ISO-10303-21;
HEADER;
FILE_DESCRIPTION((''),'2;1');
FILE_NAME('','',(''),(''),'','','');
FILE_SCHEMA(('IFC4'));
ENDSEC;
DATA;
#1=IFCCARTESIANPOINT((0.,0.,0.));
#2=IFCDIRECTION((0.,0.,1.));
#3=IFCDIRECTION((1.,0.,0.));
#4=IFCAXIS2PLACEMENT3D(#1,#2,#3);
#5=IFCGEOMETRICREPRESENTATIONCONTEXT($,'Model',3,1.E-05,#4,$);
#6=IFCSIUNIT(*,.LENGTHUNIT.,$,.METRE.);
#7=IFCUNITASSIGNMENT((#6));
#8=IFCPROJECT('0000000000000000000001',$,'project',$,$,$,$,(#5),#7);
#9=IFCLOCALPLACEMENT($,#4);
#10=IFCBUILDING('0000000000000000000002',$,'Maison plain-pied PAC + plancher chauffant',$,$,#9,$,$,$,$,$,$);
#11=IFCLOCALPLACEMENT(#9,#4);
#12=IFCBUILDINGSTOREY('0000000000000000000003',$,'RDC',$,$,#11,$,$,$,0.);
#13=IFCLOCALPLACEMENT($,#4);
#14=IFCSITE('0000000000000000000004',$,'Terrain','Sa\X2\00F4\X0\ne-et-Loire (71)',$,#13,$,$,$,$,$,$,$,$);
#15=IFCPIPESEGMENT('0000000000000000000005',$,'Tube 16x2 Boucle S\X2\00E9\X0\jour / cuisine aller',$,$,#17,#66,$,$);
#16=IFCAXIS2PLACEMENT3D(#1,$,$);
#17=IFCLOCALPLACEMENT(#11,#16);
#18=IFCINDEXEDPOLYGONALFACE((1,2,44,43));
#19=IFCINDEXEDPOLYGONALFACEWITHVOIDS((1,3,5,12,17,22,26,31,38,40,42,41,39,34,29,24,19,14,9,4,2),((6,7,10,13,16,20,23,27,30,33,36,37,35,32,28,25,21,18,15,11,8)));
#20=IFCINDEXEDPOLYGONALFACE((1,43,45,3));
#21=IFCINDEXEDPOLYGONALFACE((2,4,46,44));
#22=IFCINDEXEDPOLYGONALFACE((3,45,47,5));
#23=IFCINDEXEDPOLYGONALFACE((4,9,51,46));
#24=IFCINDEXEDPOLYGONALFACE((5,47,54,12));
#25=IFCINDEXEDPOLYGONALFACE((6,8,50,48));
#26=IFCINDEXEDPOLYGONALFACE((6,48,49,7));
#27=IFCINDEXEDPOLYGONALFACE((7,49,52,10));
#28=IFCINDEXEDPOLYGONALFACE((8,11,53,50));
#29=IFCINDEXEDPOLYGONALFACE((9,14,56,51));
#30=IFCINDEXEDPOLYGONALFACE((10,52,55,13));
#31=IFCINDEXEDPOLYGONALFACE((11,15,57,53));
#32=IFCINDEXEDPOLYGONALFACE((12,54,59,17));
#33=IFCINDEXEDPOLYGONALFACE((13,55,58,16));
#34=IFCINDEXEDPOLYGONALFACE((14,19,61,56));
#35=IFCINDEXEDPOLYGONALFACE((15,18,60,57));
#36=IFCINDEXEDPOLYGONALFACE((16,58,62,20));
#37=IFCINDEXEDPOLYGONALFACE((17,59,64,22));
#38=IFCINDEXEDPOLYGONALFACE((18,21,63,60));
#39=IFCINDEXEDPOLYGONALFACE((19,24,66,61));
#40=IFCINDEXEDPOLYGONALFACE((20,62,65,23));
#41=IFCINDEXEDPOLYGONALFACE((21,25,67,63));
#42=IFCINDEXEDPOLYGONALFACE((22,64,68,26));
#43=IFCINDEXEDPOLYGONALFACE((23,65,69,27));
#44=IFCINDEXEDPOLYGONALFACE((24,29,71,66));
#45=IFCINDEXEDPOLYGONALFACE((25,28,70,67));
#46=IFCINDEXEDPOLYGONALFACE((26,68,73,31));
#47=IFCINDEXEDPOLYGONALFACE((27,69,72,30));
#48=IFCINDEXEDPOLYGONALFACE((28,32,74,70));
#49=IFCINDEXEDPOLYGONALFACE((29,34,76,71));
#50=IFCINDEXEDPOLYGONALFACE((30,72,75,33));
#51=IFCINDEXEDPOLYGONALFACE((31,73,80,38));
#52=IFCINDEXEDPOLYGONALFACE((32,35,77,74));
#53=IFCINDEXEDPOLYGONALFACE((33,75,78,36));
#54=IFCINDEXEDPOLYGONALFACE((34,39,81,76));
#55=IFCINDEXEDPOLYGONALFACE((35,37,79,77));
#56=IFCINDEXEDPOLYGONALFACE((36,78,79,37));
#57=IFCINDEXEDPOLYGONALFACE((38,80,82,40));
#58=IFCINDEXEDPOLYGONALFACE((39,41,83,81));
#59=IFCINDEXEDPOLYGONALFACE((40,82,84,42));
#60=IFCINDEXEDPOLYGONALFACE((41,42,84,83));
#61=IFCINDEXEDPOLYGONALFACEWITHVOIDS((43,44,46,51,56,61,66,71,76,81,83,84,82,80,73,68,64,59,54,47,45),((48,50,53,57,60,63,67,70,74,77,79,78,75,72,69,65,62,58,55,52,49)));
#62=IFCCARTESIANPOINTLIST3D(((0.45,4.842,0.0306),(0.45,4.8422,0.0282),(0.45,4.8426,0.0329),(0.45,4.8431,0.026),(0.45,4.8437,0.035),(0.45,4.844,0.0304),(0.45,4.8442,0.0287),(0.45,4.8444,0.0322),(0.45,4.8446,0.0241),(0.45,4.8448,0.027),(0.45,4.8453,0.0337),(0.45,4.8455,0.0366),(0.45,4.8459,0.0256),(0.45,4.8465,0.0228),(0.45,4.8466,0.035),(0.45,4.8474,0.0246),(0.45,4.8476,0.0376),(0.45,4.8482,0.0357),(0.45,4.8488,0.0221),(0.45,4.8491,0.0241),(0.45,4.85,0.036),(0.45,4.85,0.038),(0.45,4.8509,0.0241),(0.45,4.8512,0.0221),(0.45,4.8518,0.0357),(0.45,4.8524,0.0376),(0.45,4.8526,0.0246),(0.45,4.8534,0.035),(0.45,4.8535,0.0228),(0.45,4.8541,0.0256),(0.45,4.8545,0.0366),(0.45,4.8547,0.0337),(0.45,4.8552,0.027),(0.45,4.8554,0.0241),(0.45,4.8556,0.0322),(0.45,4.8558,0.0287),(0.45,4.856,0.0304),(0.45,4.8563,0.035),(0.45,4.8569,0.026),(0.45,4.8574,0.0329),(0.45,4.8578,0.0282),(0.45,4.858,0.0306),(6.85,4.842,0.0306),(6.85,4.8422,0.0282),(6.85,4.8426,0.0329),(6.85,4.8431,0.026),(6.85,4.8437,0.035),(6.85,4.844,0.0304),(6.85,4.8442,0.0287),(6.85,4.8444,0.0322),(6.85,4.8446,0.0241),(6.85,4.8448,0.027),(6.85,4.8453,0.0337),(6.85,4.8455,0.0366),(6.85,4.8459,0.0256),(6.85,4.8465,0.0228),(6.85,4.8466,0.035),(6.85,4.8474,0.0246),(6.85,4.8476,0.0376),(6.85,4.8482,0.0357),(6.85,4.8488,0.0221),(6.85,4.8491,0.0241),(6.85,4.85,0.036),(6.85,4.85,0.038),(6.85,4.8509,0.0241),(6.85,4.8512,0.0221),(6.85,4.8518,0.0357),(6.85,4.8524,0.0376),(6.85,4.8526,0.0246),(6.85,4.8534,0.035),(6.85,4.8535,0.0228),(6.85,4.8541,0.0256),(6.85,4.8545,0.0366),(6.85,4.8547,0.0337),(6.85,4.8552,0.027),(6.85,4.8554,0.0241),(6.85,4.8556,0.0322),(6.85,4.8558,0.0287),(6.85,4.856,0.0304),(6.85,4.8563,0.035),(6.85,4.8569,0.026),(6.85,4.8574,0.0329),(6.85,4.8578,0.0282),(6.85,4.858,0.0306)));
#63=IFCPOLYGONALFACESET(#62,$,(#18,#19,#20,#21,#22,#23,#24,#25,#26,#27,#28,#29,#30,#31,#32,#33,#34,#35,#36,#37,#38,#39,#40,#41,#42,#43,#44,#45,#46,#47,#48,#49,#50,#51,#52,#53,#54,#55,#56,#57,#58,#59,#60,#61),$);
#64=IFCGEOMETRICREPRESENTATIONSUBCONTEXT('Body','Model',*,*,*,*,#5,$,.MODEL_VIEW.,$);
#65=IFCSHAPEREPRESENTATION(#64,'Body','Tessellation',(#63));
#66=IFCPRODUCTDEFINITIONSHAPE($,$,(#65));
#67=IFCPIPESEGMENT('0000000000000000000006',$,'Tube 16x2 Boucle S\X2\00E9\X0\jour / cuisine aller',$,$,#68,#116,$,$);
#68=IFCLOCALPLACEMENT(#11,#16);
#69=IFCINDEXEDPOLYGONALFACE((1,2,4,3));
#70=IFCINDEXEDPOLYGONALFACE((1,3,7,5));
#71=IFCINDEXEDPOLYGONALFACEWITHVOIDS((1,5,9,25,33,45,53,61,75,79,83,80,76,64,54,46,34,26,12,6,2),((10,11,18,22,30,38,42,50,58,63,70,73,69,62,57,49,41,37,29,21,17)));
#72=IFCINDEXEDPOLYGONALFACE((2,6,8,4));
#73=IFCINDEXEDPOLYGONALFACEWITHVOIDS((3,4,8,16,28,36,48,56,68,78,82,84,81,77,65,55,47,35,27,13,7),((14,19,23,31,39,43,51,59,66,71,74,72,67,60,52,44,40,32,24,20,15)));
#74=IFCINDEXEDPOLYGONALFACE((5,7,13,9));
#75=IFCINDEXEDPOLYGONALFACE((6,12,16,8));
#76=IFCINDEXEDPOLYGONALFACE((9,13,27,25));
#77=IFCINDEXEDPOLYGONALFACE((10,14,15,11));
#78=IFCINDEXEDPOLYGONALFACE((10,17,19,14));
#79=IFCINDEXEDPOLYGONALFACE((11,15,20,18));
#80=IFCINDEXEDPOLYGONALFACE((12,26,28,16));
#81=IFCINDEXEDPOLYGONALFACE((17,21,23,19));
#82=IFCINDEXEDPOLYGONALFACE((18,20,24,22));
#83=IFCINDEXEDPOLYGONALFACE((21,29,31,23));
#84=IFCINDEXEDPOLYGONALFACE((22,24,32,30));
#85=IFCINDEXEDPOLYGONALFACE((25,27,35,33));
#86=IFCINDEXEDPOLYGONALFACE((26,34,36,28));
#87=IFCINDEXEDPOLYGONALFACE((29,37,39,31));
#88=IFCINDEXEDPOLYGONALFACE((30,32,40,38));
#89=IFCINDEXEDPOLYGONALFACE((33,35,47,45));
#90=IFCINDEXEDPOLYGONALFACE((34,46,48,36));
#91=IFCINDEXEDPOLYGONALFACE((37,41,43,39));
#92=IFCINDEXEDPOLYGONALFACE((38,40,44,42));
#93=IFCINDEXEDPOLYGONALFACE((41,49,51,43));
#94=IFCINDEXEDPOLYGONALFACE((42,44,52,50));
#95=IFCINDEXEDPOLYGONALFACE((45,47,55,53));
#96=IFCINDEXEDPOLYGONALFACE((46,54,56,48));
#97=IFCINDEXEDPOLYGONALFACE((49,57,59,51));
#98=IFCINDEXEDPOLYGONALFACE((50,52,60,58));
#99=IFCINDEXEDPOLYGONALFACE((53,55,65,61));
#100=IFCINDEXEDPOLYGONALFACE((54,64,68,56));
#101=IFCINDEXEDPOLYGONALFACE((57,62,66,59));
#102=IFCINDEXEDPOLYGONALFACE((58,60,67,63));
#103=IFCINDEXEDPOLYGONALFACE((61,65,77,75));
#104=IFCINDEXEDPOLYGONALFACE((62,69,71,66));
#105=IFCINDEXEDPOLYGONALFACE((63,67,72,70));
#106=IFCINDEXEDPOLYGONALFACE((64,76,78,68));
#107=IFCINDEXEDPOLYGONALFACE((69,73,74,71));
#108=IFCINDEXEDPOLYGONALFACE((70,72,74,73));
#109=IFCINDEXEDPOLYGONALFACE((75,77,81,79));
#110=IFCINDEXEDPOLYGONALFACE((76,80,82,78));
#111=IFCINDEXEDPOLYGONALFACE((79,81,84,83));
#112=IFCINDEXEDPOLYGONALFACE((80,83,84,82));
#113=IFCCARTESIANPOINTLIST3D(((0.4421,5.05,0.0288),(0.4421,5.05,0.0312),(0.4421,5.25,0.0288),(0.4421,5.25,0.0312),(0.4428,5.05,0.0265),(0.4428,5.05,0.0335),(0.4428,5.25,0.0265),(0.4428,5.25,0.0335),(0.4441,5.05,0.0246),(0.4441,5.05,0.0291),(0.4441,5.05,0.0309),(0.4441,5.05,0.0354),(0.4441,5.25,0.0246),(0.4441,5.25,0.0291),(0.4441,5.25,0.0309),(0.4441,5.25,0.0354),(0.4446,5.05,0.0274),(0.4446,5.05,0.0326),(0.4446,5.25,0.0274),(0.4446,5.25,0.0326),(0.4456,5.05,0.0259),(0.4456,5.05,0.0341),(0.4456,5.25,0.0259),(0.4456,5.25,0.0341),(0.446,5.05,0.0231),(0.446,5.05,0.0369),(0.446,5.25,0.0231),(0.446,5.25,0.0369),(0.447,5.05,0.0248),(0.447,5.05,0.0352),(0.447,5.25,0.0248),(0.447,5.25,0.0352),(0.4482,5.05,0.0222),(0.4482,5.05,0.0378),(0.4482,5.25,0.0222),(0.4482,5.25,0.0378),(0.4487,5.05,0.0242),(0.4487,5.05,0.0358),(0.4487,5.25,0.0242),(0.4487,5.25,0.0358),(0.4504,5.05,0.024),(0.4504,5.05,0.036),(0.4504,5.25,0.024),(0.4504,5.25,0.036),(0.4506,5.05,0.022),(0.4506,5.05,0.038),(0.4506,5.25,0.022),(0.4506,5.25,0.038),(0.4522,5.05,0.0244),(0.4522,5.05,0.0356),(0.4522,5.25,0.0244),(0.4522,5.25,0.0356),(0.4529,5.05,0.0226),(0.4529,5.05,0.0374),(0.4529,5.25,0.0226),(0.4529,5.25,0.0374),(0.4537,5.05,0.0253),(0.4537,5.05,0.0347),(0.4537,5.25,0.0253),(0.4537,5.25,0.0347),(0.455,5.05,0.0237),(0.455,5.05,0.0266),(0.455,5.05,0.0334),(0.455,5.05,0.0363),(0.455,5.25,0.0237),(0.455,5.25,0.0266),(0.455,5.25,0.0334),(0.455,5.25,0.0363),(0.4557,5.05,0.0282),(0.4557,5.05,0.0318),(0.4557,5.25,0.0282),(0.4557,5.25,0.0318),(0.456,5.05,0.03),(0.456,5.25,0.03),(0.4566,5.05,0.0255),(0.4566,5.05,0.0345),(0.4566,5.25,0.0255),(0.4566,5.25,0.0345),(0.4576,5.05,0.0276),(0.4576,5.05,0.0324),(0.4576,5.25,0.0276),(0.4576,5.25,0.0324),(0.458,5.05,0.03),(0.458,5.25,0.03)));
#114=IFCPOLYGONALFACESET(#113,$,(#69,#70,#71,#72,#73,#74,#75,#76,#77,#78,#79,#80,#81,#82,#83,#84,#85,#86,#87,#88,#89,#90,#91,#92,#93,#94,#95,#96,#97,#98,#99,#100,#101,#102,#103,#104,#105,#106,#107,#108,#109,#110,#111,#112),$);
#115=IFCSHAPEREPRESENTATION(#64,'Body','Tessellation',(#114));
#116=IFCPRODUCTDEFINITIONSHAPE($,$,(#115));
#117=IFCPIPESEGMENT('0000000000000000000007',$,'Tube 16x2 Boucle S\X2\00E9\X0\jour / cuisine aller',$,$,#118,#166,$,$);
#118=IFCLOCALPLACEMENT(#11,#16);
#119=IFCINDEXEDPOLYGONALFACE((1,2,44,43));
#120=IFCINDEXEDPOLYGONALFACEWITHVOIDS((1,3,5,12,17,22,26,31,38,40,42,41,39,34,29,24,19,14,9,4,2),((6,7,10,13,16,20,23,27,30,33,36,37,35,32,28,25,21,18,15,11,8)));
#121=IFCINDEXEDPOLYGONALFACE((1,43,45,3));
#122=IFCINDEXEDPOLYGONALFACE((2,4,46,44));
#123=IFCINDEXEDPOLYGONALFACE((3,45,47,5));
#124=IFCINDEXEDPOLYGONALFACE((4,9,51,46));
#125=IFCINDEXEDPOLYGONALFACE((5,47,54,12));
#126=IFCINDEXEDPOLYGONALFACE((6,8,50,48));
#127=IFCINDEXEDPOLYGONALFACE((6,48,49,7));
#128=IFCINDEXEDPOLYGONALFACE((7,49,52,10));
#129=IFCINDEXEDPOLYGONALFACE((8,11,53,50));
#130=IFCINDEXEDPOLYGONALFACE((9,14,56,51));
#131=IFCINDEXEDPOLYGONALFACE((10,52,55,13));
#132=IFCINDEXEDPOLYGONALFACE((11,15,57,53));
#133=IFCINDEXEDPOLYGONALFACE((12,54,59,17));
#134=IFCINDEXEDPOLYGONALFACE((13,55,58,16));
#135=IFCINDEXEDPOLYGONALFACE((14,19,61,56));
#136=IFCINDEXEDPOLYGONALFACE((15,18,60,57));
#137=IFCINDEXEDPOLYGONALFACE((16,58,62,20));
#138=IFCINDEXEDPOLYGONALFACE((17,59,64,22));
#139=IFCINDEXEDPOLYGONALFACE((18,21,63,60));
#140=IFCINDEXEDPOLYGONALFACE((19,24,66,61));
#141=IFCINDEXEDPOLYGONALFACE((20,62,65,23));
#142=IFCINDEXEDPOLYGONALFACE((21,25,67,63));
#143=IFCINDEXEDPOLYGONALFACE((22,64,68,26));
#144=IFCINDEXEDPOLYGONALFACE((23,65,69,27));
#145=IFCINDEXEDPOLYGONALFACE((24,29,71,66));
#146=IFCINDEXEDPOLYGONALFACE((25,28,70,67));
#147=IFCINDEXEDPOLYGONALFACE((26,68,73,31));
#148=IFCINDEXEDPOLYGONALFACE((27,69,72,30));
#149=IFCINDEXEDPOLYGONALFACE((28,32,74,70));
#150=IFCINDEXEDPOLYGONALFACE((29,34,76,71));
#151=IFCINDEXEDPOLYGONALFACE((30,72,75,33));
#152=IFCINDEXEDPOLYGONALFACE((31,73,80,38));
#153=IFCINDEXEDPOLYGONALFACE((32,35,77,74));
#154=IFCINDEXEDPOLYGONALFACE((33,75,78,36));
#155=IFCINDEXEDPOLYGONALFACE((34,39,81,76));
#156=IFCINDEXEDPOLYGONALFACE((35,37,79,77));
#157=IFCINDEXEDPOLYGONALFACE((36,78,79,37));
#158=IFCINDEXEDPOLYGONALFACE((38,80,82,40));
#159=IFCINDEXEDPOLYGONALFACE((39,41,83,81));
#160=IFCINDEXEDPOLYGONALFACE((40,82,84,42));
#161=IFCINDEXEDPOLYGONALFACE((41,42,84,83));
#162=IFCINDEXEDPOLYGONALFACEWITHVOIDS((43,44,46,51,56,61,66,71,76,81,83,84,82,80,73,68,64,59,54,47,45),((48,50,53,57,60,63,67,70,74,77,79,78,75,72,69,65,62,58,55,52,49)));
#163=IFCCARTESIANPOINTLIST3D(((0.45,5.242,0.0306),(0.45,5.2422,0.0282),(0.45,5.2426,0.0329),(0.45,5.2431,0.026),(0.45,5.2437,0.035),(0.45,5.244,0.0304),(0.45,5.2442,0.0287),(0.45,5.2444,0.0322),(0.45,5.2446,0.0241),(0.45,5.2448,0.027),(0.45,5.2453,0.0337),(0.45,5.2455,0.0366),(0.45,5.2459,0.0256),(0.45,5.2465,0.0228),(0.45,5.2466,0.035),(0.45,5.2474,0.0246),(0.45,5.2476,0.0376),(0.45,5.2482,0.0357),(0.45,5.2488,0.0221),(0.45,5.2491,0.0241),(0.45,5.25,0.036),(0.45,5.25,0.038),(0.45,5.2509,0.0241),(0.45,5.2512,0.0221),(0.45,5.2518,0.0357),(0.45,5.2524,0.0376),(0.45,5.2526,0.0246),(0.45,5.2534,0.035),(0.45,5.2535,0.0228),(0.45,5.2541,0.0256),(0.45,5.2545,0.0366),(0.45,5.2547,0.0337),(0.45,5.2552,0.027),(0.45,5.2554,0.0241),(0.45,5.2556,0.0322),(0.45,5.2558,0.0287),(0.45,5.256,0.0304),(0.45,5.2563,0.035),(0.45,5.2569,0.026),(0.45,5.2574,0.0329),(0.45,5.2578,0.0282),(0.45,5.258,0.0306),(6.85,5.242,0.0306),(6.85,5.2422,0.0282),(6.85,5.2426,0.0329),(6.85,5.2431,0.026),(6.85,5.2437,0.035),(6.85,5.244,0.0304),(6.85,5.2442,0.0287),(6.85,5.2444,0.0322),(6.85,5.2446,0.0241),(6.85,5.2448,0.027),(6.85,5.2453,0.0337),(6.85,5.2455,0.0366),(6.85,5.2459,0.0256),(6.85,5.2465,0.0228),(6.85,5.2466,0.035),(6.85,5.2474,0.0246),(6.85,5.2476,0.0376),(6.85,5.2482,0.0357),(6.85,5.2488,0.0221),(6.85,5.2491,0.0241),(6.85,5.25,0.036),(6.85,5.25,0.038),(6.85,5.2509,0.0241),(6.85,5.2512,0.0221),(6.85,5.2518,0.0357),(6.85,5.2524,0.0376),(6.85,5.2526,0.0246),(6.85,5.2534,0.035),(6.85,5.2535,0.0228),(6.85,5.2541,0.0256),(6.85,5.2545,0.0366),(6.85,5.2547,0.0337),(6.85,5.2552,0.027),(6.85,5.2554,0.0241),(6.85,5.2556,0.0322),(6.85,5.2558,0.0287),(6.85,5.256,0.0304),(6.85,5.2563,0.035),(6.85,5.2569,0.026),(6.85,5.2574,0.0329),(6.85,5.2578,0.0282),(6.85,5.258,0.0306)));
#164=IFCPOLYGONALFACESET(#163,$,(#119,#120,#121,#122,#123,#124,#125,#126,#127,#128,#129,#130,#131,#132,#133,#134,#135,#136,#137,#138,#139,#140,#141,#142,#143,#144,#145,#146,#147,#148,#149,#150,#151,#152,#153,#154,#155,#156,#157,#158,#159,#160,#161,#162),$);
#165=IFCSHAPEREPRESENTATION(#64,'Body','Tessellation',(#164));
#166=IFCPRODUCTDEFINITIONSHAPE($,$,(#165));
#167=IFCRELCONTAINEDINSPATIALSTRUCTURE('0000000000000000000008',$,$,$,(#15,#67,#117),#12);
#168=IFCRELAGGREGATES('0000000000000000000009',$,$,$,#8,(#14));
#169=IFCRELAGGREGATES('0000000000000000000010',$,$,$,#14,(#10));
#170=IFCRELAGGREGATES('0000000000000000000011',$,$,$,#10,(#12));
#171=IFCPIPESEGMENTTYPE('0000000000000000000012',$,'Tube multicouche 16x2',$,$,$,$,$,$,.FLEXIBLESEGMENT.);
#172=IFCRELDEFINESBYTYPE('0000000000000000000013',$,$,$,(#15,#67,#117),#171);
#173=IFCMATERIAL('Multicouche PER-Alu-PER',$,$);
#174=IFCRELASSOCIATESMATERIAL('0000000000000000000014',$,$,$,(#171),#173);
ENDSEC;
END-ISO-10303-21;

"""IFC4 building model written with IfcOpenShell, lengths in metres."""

from ifc_helpers import new_model, si_unit, frame, origin_with_axes, place, context, subcontext, project, spatial, hollow_circle, extrude, material, type_object, element, save


model = new_model("IFC4")

# Units and contexts
model_context = context("Model", 3, precision=1e-05, world=origin_with_axes())
body_context = subcontext(model_context, "Body", "Model", "MODEL_VIEW")
ifc_project = project(units=[si_unit("LENGTHUNIT", "METRE")], contexts=[model_context])

# Site, building, storey
site_placement = place(None, origin_with_axes())
site = spatial("IfcSite", under=ifc_project, at=site_placement, Name="Terrain", Description="Saône-et-Loire (71)")
building_placement = place(None, origin_with_axes())
building = spatial("IfcBuilding", under=site, at=building_placement, Name="Maison plain-pied PAC + plancher chauffant")
storey_placement = place(building_placement, origin_with_axes())
storey = spatial("IfcBuildingStorey", under=building, at=storey_placement, Name="RDC", Elevation=0.0)

# Pipe segments
ifc_material_1 = material(Name="Multicouche PER-Alu-PER")
pipe_segment_type_1 = type_object("IfcPipeSegmentType", Name="Tube multicouche 16x2", PredefinedType="FLEXIBLESEGMENT", material=ifc_material_1)
pipe_segment_1_placement = place(storey_placement, frame((0.45, 4.85, 0.03), z_axis=(1.0, 0.0, 0.0), x_axis=(0.0, 0.0, 1.0)))
element("IfcPipeSegment", 1, at=pipe_segment_1_placement, inside=storey, type_object=pipe_segment_type_1, Name="Tube 16x2 Boucle Séjour / cuisine aller", context=body_context, shape_type="SweptSolid", body=[
    extrude(hollow_circle(Radius=0.008, WallThickness=0.002), origin_with_axes(), (0.0, 0.0, 1.0), 6.4),
])
pipe_segment_2_placement = place(storey_placement, frame((0.45, 5.05, 0.03), z_axis=(0.0, 1.0, 0.0), x_axis=(1.0, 0.0, 0.0)))
element("IfcPipeSegment", 2, at=pipe_segment_2_placement, inside=storey, type_object=pipe_segment_type_1, Name="Tube 16x2 Boucle Séjour / cuisine aller", context=body_context, shape_type="SweptSolid", body=[
    extrude(hollow_circle(Radius=0.008, WallThickness=0.002), origin_with_axes(), (0.0, 0.0, 1.0), 0.2),
])
pipe_segment_3_placement = place(storey_placement, frame((0.45, 5.25, 0.03), z_axis=(1.0, 0.0, 0.0), x_axis=(0.0, 0.0, 1.0)))
element("IfcPipeSegment", 3, at=pipe_segment_3_placement, inside=storey, type_object=pipe_segment_type_1, Name="Tube 16x2 Boucle Séjour / cuisine aller", context=body_context, shape_type="SweptSolid", body=[
    extrude(hollow_circle(Radius=0.008, WallThickness=0.002), origin_with_axes(), (0.0, 0.0, 1.0), 6.4),
])

save(model, "model.ifc")
